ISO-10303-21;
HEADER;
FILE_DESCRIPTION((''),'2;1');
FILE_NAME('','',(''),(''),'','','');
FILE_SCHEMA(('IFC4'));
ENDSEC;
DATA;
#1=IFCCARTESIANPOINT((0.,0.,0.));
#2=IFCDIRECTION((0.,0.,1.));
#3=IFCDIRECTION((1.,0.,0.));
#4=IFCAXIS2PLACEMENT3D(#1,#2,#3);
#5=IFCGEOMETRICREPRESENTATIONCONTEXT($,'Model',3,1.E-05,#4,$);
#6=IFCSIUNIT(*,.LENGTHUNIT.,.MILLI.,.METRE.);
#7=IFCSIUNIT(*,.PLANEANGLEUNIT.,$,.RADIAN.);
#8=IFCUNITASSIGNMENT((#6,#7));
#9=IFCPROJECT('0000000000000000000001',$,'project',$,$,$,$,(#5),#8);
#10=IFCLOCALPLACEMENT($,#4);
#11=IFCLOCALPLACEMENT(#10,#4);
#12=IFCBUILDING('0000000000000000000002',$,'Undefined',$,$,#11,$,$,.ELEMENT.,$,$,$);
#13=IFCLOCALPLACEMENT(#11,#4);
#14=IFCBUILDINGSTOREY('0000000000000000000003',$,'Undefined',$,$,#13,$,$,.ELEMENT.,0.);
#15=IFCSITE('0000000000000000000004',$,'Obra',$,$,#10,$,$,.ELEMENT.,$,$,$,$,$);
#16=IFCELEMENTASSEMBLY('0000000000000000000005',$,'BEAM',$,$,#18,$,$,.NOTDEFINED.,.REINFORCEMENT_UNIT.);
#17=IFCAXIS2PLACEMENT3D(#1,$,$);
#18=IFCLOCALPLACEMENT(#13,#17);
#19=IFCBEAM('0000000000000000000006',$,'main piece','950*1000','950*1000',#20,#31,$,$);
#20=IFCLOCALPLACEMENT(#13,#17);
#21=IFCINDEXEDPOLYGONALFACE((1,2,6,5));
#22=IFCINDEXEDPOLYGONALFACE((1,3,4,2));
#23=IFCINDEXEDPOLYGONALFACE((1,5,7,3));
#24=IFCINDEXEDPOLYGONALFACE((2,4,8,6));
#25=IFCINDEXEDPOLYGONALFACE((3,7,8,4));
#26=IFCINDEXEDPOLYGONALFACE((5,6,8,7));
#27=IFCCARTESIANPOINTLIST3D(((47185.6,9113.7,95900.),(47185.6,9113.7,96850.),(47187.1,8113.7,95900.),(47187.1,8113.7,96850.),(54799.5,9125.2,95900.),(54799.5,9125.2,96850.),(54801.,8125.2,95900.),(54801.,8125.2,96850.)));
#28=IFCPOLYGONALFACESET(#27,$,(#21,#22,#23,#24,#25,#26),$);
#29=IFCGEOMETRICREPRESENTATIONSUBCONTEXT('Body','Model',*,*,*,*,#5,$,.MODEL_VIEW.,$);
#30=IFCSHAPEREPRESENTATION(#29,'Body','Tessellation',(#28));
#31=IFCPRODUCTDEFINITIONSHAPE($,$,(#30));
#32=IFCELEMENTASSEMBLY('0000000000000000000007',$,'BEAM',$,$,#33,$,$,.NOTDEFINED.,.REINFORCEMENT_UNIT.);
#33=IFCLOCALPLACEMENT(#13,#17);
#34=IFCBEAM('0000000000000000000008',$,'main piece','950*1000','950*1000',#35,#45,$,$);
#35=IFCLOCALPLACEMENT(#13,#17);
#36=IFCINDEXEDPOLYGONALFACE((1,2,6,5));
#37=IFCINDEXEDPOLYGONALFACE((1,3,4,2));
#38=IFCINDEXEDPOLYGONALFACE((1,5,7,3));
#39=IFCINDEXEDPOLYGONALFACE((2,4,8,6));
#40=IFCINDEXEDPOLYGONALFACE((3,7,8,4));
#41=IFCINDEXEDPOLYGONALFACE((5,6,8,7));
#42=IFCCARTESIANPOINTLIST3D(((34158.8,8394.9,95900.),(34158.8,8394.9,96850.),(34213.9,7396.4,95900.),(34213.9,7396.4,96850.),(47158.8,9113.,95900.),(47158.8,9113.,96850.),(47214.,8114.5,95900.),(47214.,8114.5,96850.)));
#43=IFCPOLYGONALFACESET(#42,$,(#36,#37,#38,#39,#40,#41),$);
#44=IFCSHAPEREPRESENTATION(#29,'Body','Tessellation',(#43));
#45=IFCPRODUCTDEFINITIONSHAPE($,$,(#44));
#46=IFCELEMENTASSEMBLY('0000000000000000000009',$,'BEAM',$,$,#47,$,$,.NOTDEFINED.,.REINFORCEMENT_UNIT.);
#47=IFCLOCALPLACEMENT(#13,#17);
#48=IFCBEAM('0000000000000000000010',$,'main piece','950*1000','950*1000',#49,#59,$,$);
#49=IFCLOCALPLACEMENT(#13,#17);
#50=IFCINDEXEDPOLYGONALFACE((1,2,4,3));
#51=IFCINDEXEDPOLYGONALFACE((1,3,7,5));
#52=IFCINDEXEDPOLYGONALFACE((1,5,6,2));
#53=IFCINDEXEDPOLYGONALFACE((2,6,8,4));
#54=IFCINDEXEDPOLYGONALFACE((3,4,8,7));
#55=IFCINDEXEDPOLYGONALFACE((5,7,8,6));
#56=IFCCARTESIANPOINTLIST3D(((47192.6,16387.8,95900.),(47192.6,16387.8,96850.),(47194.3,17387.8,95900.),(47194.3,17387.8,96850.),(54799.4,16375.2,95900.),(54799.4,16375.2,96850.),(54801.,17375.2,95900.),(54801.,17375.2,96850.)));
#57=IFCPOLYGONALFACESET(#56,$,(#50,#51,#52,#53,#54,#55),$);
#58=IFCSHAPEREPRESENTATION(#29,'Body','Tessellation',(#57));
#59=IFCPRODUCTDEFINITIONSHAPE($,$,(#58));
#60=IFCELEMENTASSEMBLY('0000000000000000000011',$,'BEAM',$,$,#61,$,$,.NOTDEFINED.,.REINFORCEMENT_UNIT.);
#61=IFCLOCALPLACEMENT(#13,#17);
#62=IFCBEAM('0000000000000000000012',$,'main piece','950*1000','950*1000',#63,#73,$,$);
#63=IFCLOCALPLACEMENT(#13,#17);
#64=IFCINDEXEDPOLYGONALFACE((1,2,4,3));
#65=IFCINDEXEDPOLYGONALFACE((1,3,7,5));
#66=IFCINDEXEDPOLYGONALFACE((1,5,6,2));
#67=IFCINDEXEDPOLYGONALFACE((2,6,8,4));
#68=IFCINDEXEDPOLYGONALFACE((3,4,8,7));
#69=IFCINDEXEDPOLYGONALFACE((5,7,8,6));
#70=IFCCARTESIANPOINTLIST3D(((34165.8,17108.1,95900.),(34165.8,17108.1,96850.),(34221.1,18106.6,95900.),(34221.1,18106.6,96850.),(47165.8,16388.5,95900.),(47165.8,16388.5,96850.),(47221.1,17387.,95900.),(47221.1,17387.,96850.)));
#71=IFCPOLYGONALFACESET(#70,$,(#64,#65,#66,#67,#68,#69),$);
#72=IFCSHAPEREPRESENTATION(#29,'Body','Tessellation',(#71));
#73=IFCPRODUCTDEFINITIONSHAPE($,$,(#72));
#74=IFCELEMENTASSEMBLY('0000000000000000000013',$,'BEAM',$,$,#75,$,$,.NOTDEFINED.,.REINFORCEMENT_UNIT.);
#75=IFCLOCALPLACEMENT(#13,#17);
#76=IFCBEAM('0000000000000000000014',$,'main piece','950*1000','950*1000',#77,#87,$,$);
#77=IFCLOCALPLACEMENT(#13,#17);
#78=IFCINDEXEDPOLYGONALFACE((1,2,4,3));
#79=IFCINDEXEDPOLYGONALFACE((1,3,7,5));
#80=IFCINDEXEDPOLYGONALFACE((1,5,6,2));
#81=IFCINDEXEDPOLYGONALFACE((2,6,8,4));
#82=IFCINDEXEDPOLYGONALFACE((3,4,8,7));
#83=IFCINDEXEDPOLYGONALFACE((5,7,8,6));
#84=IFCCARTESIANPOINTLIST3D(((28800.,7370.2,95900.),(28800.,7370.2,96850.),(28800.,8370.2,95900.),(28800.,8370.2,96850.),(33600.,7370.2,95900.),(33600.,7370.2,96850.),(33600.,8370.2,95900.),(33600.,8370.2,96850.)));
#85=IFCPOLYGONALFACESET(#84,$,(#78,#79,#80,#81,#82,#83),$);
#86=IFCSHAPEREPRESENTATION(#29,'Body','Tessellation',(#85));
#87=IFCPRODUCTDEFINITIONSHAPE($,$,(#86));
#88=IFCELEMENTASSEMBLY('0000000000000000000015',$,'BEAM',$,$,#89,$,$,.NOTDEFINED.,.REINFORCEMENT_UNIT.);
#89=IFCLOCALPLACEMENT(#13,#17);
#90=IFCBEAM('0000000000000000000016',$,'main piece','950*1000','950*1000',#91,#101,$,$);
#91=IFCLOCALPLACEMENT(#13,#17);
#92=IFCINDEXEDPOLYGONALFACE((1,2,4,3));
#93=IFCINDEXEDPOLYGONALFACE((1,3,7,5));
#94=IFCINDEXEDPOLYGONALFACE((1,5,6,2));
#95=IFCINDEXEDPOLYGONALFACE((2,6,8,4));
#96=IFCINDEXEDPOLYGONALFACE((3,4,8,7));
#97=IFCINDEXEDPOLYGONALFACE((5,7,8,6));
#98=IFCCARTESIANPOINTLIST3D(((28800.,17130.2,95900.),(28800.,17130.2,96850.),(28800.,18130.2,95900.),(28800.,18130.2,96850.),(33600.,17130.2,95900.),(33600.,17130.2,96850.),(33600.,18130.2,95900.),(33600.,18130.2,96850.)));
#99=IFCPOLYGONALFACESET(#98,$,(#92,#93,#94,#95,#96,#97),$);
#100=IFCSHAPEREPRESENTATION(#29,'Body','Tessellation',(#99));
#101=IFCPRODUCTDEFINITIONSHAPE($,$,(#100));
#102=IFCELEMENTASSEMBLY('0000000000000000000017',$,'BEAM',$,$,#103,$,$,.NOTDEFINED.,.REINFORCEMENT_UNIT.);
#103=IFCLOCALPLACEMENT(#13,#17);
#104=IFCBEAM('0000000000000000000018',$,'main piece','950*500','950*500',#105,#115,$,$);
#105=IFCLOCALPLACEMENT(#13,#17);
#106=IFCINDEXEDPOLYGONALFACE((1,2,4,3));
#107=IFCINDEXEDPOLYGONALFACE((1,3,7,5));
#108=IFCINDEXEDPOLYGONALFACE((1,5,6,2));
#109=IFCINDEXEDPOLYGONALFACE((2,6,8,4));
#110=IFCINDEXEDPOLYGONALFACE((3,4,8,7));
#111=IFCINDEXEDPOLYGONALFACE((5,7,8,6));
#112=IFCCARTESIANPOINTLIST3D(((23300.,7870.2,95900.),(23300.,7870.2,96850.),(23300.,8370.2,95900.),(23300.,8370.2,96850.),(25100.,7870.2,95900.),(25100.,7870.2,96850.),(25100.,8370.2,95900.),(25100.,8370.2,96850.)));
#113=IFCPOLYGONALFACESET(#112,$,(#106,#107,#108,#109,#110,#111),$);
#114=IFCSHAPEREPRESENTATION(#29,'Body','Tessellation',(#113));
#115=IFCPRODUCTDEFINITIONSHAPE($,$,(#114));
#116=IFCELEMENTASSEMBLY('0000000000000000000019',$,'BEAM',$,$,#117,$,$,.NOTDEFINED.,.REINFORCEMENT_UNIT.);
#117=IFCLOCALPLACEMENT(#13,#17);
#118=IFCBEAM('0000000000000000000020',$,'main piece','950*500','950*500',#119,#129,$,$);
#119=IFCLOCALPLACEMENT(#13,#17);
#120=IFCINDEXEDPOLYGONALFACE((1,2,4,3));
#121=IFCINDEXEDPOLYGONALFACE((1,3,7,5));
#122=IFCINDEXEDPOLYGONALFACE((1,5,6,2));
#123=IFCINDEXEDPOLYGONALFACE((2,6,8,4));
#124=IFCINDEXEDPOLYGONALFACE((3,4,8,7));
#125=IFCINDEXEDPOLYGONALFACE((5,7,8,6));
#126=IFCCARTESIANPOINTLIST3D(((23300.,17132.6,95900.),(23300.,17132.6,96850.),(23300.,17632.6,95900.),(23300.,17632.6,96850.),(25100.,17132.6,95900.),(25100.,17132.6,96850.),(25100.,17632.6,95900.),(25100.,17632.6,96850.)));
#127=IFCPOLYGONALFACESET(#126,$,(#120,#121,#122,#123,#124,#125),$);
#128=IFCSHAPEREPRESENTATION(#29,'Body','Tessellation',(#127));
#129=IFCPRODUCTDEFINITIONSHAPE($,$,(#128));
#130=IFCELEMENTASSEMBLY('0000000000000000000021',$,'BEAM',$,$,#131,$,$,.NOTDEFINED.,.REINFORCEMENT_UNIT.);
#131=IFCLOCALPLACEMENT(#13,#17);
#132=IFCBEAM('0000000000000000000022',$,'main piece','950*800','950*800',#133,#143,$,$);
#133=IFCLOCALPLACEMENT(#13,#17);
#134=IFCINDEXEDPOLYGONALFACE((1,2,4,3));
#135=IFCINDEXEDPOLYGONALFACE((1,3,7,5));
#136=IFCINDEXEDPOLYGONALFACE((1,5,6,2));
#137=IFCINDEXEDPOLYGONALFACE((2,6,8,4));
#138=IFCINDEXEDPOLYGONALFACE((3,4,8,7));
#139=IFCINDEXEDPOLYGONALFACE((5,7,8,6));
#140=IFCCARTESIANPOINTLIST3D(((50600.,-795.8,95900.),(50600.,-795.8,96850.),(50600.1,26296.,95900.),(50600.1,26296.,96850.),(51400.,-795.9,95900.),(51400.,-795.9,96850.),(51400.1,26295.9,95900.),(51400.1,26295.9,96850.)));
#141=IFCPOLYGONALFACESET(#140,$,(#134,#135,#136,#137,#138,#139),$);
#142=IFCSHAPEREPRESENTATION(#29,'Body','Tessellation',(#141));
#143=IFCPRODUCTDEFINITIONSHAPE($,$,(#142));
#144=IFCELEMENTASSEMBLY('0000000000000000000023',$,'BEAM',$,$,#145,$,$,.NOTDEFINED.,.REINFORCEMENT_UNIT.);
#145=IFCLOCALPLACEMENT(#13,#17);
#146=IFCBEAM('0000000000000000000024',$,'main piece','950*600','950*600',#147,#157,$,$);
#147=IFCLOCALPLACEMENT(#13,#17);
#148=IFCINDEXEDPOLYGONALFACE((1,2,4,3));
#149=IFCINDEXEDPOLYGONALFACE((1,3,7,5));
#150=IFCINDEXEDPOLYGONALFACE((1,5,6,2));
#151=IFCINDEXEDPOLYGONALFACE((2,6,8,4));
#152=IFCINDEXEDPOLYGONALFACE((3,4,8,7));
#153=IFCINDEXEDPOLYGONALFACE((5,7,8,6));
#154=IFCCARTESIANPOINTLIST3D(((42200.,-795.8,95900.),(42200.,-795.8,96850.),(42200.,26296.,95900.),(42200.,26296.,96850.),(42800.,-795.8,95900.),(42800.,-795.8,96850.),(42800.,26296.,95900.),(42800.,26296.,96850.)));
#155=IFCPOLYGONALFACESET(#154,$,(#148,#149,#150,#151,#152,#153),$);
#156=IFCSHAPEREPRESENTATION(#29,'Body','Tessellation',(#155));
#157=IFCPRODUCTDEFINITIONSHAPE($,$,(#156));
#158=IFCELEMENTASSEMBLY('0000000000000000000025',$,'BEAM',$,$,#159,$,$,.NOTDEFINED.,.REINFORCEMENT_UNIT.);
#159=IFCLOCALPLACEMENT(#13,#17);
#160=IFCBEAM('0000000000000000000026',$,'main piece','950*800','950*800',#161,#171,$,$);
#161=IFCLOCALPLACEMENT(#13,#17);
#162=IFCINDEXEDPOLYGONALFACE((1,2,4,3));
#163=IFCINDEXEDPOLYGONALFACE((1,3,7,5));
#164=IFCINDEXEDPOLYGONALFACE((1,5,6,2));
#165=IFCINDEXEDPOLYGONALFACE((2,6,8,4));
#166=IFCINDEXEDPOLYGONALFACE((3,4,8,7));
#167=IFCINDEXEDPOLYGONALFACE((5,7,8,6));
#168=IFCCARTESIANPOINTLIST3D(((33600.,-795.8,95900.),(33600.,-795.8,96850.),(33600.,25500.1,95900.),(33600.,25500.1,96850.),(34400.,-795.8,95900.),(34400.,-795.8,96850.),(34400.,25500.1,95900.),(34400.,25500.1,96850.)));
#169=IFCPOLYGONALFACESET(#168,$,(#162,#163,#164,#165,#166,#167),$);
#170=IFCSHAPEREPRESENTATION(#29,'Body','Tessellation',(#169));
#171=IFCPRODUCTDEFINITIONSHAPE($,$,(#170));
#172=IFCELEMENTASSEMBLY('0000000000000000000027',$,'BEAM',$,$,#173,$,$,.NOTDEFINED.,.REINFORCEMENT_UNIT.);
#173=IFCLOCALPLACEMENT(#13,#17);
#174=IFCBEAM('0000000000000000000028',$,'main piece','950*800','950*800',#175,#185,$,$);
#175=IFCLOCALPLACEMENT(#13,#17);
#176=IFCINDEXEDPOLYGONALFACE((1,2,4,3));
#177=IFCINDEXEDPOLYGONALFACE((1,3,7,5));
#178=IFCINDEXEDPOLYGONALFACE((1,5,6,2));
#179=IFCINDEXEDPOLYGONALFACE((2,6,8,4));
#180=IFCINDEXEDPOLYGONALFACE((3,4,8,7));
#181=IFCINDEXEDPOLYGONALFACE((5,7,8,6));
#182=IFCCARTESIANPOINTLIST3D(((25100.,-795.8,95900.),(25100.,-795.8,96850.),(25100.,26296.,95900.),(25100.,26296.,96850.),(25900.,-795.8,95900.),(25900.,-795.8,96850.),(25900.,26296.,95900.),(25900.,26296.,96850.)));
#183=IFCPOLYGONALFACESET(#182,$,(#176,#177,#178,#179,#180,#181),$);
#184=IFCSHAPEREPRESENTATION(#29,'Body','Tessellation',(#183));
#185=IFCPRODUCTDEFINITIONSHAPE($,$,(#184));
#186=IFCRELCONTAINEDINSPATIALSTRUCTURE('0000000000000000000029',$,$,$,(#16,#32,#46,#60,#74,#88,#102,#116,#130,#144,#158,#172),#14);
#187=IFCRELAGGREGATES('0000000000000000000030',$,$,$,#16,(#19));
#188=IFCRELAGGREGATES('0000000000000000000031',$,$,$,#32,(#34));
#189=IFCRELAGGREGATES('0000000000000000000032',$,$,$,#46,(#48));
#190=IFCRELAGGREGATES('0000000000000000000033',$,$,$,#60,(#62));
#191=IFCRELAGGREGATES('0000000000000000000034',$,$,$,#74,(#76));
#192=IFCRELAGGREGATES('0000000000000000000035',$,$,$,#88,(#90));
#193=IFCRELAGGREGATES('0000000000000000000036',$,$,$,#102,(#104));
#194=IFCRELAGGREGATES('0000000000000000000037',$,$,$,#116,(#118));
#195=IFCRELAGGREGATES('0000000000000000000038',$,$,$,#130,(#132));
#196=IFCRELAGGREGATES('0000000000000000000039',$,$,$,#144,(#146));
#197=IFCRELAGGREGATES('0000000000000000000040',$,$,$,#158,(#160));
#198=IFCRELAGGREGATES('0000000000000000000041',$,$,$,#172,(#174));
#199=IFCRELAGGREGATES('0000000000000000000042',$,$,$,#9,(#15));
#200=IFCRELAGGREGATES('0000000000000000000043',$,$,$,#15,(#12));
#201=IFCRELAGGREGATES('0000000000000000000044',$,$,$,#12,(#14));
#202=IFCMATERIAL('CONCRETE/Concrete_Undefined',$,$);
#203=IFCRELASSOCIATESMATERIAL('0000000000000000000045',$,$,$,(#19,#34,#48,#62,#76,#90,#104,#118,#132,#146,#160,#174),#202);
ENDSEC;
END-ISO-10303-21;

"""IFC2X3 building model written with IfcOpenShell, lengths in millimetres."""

from ifc_helpers import new_model, si_unit, frame, origin_with_axes, origin_2d_with_axis, place, context, subcontext, project, spatial, rectangle, extrude, material, element, aggregate, save


model = new_model("IFC2X3")

# Units and contexts
model_context = context("Model", 3, precision=1e-05, world=origin_with_axes())
body_context = subcontext(model_context, "Body", "Model", "MODEL_VIEW")
ifc_project = project(units=[si_unit("LENGTHUNIT", "METRE", prefix="MILLI"), si_unit("PLANEANGLEUNIT", "RADIAN")], contexts=[model_context])

# Site, building, storey
site_placement = place(None, origin_with_axes())
site = spatial("IfcSite", under=ifc_project, at=site_placement, Name="Obra", CompositionType="ELEMENT")
building_placement = place(site_placement, origin_with_axes())
building = spatial("IfcBuilding", under=site, at=building_placement, Name="Undefined", CompositionType="ELEMENT")
storey_placement = place(building_placement, origin_with_axes())
storey = spatial("IfcBuildingStorey", under=building, at=storey_placement, Name="Undefined", CompositionType="ELEMENT", Elevation=0.0)

# Element assemblies, beams
assembly_1_placement = place(storey_placement, origin_with_axes())
assembly_1 = element("IfcElementAssembly", 1, at=assembly_1_placement, inside=storey, Name="BEAM", AssemblyPlace="NOTDEFINED", PredefinedType="REINFORCEMENT_UNIT")
ifc_material_1 = material(Name="CONCRETE/Concrete_Undefined")
beam_1_placement = place(assembly_1_placement, frame((47186.4, 8613.7, 96375.0), z_axis=(0.0, 0.0, 1.0), x_axis=(0.999999, 0.001508, 0.0)))
beam_1 = element("IfcBeam", 2, at=beam_1_placement, material=ifc_material_1, Name="main piece", Description="950*1000", ObjectType="950*1000", context=body_context, shape_type="SweptSolid", body=[
    extrude(rectangle(XDim=1000.0, YDim=950.0, at=origin_2d_with_axis()), frame((7613.8, 0.0, 0.0), z_axis=(-1.0, 0.0, 0.0), x_axis=(0.0, -1.0, 0.0)), (0.0, 0.0, 1.0), 7613.8),
])
aggregate(assembly_1, [beam_1])
assembly_2_placement = place(storey_placement, origin_with_axes())
assembly_2 = element("IfcElementAssembly", 3, at=assembly_2_placement, inside=storey, Name="BEAM", AssemblyPlace="NOTDEFINED", PredefinedType="REINFORCEMENT_UNIT")
beam_2_placement = place(assembly_2_placement, frame((34186.4, 7895.7, 96375.0), z_axis=(0.0, 0.0, 1.0), x_axis=(0.998478, 0.055152, 0.0)))
beam_2 = element("IfcBeam", 4, at=beam_2_placement, material=ifc_material_1, Name="main piece", Description="950*1000", ObjectType="950*1000", context=body_context, shape_type="SweptSolid", body=[
    extrude(rectangle(XDim=1000.0, YDim=950.0, at=origin_2d_with_axis()), frame((13019.8, 0.0, 0.0), z_axis=(-1.0, 0.0, 0.0), x_axis=(0.0, -1.0, 0.0)), (0.0, 0.0, 1.0), 13019.8),
])
aggregate(assembly_2, [beam_2])
assembly_3_placement = place(storey_placement, origin_with_axes())
assembly_3 = element("IfcElementAssembly", 5, at=assembly_3_placement, inside=storey, Name="BEAM", AssemblyPlace="NOTDEFINED", PredefinedType="REINFORCEMENT_UNIT")
beam_3_placement = place(assembly_3_placement, frame((47193.5, 16887.8, 96375.0), z_axis=(0.0, 0.0, 1.0), x_axis=(0.999999, -0.001649, 0.0)))
beam_3 = element("IfcBeam", 6, at=beam_3_placement, material=ifc_material_1, Name="main piece", Description="950*1000", ObjectType="950*1000", context=body_context, shape_type="SweptSolid", body=[
    extrude(rectangle(XDim=1000.0, YDim=950.0, at=origin_2d_with_axis()), frame((7606.8, 0.0, 0.0), z_axis=(-1.0, 0.0, 0.0), x_axis=(0.0, -1.0, 0.0)), (0.0, 0.0, 1.0), 7606.8),
])
aggregate(assembly_3, [beam_3])
assembly_4_placement = place(storey_placement, origin_with_axes())
assembly_4 = element("IfcElementAssembly", 7, at=assembly_4_placement, inside=storey, Name="BEAM", AssemblyPlace="NOTDEFINED", PredefinedType="REINFORCEMENT_UNIT")
beam_4_placement = place(assembly_4_placement, frame((34193.5, 17607.3, 96375.0), z_axis=(0.0, 0.0, 1.0), x_axis=(0.998472, -0.055268, 0.0)))
beam_4 = element("IfcBeam", 8, at=beam_4_placement, material=ifc_material_1, Name="main piece", Description="950*1000", ObjectType="950*1000", context=body_context, shape_type="SweptSolid", body=[
    extrude(rectangle(XDim=1000.0, YDim=950.0, at=origin_2d_with_axis()), frame((13019.9, 0.0, 0.0), z_axis=(-1.0, 0.0, 0.0), x_axis=(0.0, -1.0, 0.0)), (0.0, 0.0, 1.0), 13019.9),
])
aggregate(assembly_4, [beam_4])
assembly_5_placement = place(storey_placement, origin_with_axes())
assembly_5 = element("IfcElementAssembly", 9, at=assembly_5_placement, inside=storey, Name="BEAM", AssemblyPlace="NOTDEFINED", PredefinedType="REINFORCEMENT_UNIT")
beam_5_placement = place(assembly_5_placement, frame((28800.0, 7870.2, 96375.0), z_axis=(0.0, 0.0, 1.0), x_axis=(1.0, 0.000005, 0.0)))
beam_5 = element("IfcBeam", 10, at=beam_5_placement, material=ifc_material_1, Name="main piece", Description="950*1000", ObjectType="950*1000", context=body_context, shape_type="SweptSolid", body=[
    extrude(rectangle(XDim=1000.0, YDim=950.0, at=origin_2d_with_axis()), frame((4800.0, 0.0, 0.0), z_axis=(-1.0, 0.0, 0.0), x_axis=(0.0, -1.0, 0.0)), (0.0, 0.0, 1.0), 4800.0),
])
aggregate(assembly_5, [beam_5])
assembly_6_placement = place(storey_placement, origin_with_axes())
assembly_6 = element("IfcElementAssembly", 11, at=assembly_6_placement, inside=storey, Name="BEAM", AssemblyPlace="NOTDEFINED", PredefinedType="REINFORCEMENT_UNIT")
beam_6_placement = place(assembly_6_placement, frame((28800.0, 17630.2, 96375.0), z_axis=(0.0, 0.0, 1.0), x_axis=(1.0, 0.000001, 0.0)))
beam_6 = element("IfcBeam", 12, at=beam_6_placement, material=ifc_material_1, Name="main piece", Description="950*1000", ObjectType="950*1000", context=body_context, shape_type="SweptSolid", body=[
    extrude(rectangle(XDim=1000.0, YDim=950.0, at=origin_2d_with_axis()), frame((4800.0, 0.0, 0.0), z_axis=(-1.0, 0.0, 0.0), x_axis=(0.0, -1.0, 0.0)), (0.0, 0.0, 1.0), 4800.0),
])
aggregate(assembly_6, [beam_6])
assembly_7_placement = place(storey_placement, origin_with_axes())
assembly_7 = element("IfcElementAssembly", 13, at=assembly_7_placement, inside=storey, Name="BEAM", AssemblyPlace="NOTDEFINED", PredefinedType="REINFORCEMENT_UNIT")
beam_7_placement = place(assembly_7_placement, frame((25100.0, 8120.2, 96375.0), z_axis=(0.0, 0.0, 1.0), x_axis=(-1.0, 0.0, 0.0)))
beam_7 = element("IfcBeam", 14, at=beam_7_placement, material=ifc_material_1, Name="main piece", Description="950*500", ObjectType="950*500", context=body_context, shape_type="SweptSolid", body=[
    extrude(rectangle(XDim=500.0, YDim=950.0, at=origin_2d_with_axis()), frame((1800.0, 0.0, 0.0), z_axis=(-1.0, 0.0, 0.0), x_axis=(0.0, -1.0, 0.0)), (0.0, 0.0, 1.0), 1800.0),
])
aggregate(assembly_7, [beam_7])
assembly_8_placement = place(storey_placement, origin_with_axes())
assembly_8 = element("IfcElementAssembly", 15, at=assembly_8_placement, inside=storey, Name="BEAM", AssemblyPlace="NOTDEFINED", PredefinedType="REINFORCEMENT_UNIT")
beam_8_placement = place(assembly_8_placement, frame((25100.0, 17382.6, 96375.0), z_axis=(0.0, 0.0, 1.0), x_axis=(-1.0, 0.0, 0.0)))
beam_8 = element("IfcBeam", 16, at=beam_8_placement, material=ifc_material_1, Name="main piece", Description="950*500", ObjectType="950*500", context=body_context, shape_type="SweptSolid", body=[
    extrude(rectangle(XDim=500.0, YDim=950.0, at=origin_2d_with_axis()), frame((1800.0, 0.0, 0.0), z_axis=(-1.0, 0.0, 0.0), x_axis=(0.0, -1.0, 0.0)), (0.0, 0.0, 1.0), 1800.0),
])
aggregate(assembly_8, [beam_8])
assembly_9_placement = place(storey_placement, origin_with_axes())
assembly_9 = element("IfcElementAssembly", 17, at=assembly_9_placement, inside=storey, Name="BEAM", AssemblyPlace="NOTDEFINED", PredefinedType="REINFORCEMENT_UNIT")
beam_9_placement = place(assembly_9_placement, frame((51000.0, -795.8, 96375.0), z_axis=(0.0, 0.0, 1.0), x_axis=(0.000003, 1.0, 0.0)))
beam_9 = element("IfcBeam", 18, at=beam_9_placement, material=ifc_material_1, Name="main piece", Description="950*800", ObjectType="950*800", context=body_context, shape_type="SweptSolid", body=[
    extrude(rectangle(XDim=800.0, YDim=950.0, at=origin_2d_with_axis()), frame((27091.8, 0.0, 0.0), z_axis=(-1.0, 0.0, 0.0), x_axis=(0.0, -1.0, 0.0)), (0.0, 0.0, 1.0), 27091.8),
])
aggregate(assembly_9, [beam_9])
assembly_10_placement = place(storey_placement, origin_with_axes())
assembly_10 = element("IfcElementAssembly", 19, at=assembly_10_placement, inside=storey, Name="BEAM", AssemblyPlace="NOTDEFINED", PredefinedType="REINFORCEMENT_UNIT")
beam_10_placement = place(assembly_10_placement, frame((42500.0, -795.8, 96375.0), z_axis=(0.0, 0.0, 1.0), x_axis=(0.0, 1.0, 0.0)))
beam_10 = element("IfcBeam", 20, at=beam_10_placement, material=ifc_material_1, Name="main piece", Description="950*600", ObjectType="950*600", context=body_context, shape_type="SweptSolid", body=[
    extrude(rectangle(XDim=600.0, YDim=950.0, at=origin_2d_with_axis()), frame((27091.8, 0.0, 0.0), z_axis=(-1.0, 0.0, 0.0), x_axis=(0.0, -1.0, 0.0)), (0.0, 0.0, 1.0), 27091.8),
])
aggregate(assembly_10, [beam_10])
assembly_11_placement = place(storey_placement, origin_with_axes())
assembly_11 = element("IfcElementAssembly", 21, at=assembly_11_placement, inside=storey, Name="BEAM", AssemblyPlace="NOTDEFINED", PredefinedType="REINFORCEMENT_UNIT")
beam_11_placement = place(assembly_11_placement, frame((34000.0, -795.8, 96375.0), z_axis=(0.0, 0.0, 1.0), x_axis=(0.0, 1.0, 0.0)))
beam_11 = element("IfcBeam", 22, at=beam_11_placement, material=ifc_material_1, Name="main piece", Description="950*800", ObjectType="950*800", context=body_context, shape_type="SweptSolid", body=[
    extrude(rectangle(XDim=800.0, YDim=950.0, at=origin_2d_with_axis()), frame((26296.0, 0.0, 0.0), z_axis=(-1.0, 0.0, 0.0), x_axis=(0.0, -1.0, 0.0)), (0.0, 0.0, 1.0), 26296.0),
])
aggregate(assembly_11, [beam_11])
assembly_12_placement = place(storey_placement, origin_with_axes())
assembly_12 = element("IfcElementAssembly", 23, at=assembly_12_placement, inside=storey, Name="BEAM", AssemblyPlace="NOTDEFINED", PredefinedType="REINFORCEMENT_UNIT")
beam_12_placement = place(assembly_12_placement, frame((25500.0, -795.8, 96375.0), z_axis=(0.0, 0.0, 1.0), x_axis=(0.0, 1.0, 0.0)))
beam_12 = element("IfcBeam", 24, at=beam_12_placement, material=ifc_material_1, Name="main piece", Description="950*800", ObjectType="950*800", context=body_context, shape_type="SweptSolid", body=[
    extrude(rectangle(XDim=800.0, YDim=950.0, at=origin_2d_with_axis()), frame((27091.8, 0.0, 0.0), z_axis=(-1.0, 0.0, 0.0), x_axis=(0.0, -1.0, 0.0)), (0.0, 0.0, 1.0), 27091.8),
])
aggregate(assembly_12, [beam_12])

save(model, "model.ifc")
